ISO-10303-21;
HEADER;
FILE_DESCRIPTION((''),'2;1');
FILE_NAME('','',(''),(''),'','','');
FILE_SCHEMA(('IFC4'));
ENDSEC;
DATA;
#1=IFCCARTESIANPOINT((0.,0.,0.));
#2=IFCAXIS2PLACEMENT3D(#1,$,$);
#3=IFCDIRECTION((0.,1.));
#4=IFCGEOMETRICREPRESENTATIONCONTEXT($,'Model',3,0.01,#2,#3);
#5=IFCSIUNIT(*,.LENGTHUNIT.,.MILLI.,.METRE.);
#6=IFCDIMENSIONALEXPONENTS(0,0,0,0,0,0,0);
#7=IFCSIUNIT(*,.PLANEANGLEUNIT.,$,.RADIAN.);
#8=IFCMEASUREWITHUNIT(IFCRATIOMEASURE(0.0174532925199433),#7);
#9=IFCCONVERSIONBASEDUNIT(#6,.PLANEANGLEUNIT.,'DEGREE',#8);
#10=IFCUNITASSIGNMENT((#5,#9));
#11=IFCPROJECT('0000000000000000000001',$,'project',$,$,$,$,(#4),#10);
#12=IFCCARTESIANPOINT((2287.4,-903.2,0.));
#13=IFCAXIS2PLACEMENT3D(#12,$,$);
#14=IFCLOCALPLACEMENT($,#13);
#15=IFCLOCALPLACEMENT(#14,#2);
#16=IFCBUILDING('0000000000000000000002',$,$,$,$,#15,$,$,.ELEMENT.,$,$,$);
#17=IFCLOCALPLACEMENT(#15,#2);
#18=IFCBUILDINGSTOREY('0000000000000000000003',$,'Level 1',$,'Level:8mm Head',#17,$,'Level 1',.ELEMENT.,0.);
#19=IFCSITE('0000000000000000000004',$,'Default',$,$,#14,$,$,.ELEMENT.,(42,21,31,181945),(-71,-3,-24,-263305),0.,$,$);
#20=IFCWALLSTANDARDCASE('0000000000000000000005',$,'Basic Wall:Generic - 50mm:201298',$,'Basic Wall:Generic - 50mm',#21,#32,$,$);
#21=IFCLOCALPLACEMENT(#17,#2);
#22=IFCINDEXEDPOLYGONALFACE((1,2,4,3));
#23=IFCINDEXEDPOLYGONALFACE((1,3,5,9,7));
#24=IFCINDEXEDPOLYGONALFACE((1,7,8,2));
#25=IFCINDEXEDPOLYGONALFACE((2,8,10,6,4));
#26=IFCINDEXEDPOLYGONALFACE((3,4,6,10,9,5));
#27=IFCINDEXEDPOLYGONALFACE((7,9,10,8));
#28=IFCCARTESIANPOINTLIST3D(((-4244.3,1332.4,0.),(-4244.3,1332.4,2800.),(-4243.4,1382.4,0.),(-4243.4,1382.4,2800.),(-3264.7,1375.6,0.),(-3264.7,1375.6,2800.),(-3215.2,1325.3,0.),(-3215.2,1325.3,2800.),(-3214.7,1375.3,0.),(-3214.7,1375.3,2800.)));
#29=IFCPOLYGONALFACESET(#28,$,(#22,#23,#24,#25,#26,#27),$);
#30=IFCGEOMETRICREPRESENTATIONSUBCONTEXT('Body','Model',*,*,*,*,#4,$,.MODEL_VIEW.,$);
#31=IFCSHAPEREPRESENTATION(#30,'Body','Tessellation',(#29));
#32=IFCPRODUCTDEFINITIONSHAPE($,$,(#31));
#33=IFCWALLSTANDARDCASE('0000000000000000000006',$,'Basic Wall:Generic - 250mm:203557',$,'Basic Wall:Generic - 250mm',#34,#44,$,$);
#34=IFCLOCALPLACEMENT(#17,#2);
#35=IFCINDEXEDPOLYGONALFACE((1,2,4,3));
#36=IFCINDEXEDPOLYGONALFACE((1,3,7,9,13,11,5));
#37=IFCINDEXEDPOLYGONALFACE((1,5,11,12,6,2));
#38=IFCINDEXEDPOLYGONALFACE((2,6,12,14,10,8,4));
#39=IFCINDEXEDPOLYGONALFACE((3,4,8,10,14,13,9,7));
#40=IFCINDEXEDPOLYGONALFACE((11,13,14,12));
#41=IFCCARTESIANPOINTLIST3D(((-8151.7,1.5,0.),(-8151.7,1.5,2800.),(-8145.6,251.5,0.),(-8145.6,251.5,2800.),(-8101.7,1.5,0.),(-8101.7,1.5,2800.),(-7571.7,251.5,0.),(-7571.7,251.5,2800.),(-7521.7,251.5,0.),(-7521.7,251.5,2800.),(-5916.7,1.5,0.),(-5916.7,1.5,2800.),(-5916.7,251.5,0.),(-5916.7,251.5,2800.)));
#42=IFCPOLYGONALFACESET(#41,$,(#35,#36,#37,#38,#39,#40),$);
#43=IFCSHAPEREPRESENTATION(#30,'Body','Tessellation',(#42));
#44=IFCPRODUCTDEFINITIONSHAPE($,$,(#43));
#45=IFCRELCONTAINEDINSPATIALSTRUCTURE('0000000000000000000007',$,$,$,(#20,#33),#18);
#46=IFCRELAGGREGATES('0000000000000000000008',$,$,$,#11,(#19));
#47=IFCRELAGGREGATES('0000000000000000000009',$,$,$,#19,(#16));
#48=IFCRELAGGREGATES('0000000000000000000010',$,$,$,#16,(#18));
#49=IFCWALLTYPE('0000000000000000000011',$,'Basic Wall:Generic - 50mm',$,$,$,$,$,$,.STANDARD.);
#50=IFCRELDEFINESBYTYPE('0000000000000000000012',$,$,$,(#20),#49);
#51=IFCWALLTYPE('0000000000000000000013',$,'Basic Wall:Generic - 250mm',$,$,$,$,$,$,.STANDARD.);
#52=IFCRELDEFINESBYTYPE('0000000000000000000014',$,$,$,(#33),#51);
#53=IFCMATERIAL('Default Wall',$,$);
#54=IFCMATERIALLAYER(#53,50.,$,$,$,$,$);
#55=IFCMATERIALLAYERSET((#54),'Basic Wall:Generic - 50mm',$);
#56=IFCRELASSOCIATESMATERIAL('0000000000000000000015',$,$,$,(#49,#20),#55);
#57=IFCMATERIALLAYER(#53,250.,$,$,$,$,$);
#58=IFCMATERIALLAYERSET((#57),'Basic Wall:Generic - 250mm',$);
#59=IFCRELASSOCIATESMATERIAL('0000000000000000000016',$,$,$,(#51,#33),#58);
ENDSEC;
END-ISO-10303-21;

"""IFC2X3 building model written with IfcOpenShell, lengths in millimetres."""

from ifc_helpers import new_model, entity, si_unit, converted_unit, direction, frame, origin, place, context, subcontext, project, spatial, polyline, outline, extrude, material, layer, layer_set, layer_usage, type_object, element, save


model = new_model("IFC2X3")

# Units and contexts
model_context = context("Model", 3, precision=0.01, world=origin(), true_north=direction((0.0, 1.0)))
body_context = subcontext(model_context, "Body", "Model", "MODEL_VIEW")
ifc_project = project(units=[si_unit("LENGTHUNIT", "METRE", prefix="MILLI"), converted_unit("PLANEANGLEUNIT", "DEGREE", entity("IfcRatioMeasure", 0.0174532925199433), si_unit("PLANEANGLEUNIT", "RADIAN"), dimensions=[0, 0, 0, 0, 0, 0, 0])], contexts=[model_context])

# Site, building, storey
site_placement = place(None, frame((2287.4, -903.2, 0.0)))
site = spatial("IfcSite", under=ifc_project, at=site_placement, Name="Default", CompositionType="ELEMENT", RefLatitude=(42, 21, 31, 181945), RefLongitude=(-71, -3, -24, -263305), RefElevation=0.0)
building_placement = place(site_placement, origin())
building = spatial("IfcBuilding", under=site, at=building_placement, CompositionType="ELEMENT")
storey_placement = place(building_placement, origin())
storey = spatial("IfcBuildingStorey", under=building, at=storey_placement, Name="Level 1", ObjectType="Level:8mm Head", LongName="Level 1", CompositionType="ELEMENT", Elevation=0.0)

# Wall
ifc_material_1 = material(Name="Default Wall")
ifc_layer_1 = layer(ifc_material_1, 50.0)
ifc_layer_set_1 = layer_set([ifc_layer_1], Name="Basic Wall:Generic - 50mm")
ifc_layer_usage_1 = layer_usage(ifc_layer_set_1, "AXIS2", "POSITIVE", -25.0)
wall_type_1 = type_object("IfcWallType", Name="Basic Wall:Generic - 50mm", PredefinedType="STANDARD", material=ifc_layer_set_1)
wall_1_placement = place(storey_placement, frame((-4244.1, 1357.4, 0.0), z_axis=(0.0, 0.0, 1.0), x_axis=(0.999976, -0.006882, 0.0)))
element("IfcWallStandardCase", 1, at=wall_1_placement, inside=storey, type_object=wall_type_1, material=ifc_layer_usage_1, Name="Basic Wall:Generic - 50mm:201298", ObjectType="Basic Wall:Generic - 50mm", context=body_context, shape_type="SweptSolid", body=[
    extrude(outline(polyline([(1029.1, -25.0), (1029.3, 25.0), (979.3, 25.0), (0.6, 25.0), (0.0, -25.0), (1029.1, -25.0)])), origin(), (0.0, 0.0, 1.0), 2800.0),
])

# Wall
ifc_layer_2 = layer(ifc_material_1, 250.0)
ifc_layer_set_2 = layer_set([ifc_layer_2], Name="Basic Wall:Generic - 250mm")
ifc_layer_usage_2 = layer_usage(ifc_layer_set_2, "AXIS2", "NEGATIVE", 125.0)
wall_type_2 = type_object("IfcWallType", Name="Basic Wall:Generic - 250mm", PredefinedType="STANDARD", material=ifc_layer_set_2)
wall_2_placement = place(storey_placement, frame((-5916.7, 126.5, 0.0), z_axis=(0.0, 0.0, 1.0), x_axis=(-1.0, 0.0, 0.0)))
element("IfcWallStandardCase", 2, at=wall_2_placement, inside=storey, type_object=wall_type_2, material=ifc_layer_usage_2, Name="Basic Wall:Generic - 250mm:203557", ObjectType="Basic Wall:Generic - 250mm", context=body_context, shape_type="SweptSolid", body=[
    extrude(outline(polyline([(2228.9, -125.0), (2235.0, 125.0), (2185.0, 125.0), (0.0, 125.0), (0.0, -125.0), (1605.0, -125.0), (1655.0, -125.0), (2228.9, -125.0)])), origin(), (0.0, 0.0, 1.0), 2800.0),
])

save(model, "model.ifc")
